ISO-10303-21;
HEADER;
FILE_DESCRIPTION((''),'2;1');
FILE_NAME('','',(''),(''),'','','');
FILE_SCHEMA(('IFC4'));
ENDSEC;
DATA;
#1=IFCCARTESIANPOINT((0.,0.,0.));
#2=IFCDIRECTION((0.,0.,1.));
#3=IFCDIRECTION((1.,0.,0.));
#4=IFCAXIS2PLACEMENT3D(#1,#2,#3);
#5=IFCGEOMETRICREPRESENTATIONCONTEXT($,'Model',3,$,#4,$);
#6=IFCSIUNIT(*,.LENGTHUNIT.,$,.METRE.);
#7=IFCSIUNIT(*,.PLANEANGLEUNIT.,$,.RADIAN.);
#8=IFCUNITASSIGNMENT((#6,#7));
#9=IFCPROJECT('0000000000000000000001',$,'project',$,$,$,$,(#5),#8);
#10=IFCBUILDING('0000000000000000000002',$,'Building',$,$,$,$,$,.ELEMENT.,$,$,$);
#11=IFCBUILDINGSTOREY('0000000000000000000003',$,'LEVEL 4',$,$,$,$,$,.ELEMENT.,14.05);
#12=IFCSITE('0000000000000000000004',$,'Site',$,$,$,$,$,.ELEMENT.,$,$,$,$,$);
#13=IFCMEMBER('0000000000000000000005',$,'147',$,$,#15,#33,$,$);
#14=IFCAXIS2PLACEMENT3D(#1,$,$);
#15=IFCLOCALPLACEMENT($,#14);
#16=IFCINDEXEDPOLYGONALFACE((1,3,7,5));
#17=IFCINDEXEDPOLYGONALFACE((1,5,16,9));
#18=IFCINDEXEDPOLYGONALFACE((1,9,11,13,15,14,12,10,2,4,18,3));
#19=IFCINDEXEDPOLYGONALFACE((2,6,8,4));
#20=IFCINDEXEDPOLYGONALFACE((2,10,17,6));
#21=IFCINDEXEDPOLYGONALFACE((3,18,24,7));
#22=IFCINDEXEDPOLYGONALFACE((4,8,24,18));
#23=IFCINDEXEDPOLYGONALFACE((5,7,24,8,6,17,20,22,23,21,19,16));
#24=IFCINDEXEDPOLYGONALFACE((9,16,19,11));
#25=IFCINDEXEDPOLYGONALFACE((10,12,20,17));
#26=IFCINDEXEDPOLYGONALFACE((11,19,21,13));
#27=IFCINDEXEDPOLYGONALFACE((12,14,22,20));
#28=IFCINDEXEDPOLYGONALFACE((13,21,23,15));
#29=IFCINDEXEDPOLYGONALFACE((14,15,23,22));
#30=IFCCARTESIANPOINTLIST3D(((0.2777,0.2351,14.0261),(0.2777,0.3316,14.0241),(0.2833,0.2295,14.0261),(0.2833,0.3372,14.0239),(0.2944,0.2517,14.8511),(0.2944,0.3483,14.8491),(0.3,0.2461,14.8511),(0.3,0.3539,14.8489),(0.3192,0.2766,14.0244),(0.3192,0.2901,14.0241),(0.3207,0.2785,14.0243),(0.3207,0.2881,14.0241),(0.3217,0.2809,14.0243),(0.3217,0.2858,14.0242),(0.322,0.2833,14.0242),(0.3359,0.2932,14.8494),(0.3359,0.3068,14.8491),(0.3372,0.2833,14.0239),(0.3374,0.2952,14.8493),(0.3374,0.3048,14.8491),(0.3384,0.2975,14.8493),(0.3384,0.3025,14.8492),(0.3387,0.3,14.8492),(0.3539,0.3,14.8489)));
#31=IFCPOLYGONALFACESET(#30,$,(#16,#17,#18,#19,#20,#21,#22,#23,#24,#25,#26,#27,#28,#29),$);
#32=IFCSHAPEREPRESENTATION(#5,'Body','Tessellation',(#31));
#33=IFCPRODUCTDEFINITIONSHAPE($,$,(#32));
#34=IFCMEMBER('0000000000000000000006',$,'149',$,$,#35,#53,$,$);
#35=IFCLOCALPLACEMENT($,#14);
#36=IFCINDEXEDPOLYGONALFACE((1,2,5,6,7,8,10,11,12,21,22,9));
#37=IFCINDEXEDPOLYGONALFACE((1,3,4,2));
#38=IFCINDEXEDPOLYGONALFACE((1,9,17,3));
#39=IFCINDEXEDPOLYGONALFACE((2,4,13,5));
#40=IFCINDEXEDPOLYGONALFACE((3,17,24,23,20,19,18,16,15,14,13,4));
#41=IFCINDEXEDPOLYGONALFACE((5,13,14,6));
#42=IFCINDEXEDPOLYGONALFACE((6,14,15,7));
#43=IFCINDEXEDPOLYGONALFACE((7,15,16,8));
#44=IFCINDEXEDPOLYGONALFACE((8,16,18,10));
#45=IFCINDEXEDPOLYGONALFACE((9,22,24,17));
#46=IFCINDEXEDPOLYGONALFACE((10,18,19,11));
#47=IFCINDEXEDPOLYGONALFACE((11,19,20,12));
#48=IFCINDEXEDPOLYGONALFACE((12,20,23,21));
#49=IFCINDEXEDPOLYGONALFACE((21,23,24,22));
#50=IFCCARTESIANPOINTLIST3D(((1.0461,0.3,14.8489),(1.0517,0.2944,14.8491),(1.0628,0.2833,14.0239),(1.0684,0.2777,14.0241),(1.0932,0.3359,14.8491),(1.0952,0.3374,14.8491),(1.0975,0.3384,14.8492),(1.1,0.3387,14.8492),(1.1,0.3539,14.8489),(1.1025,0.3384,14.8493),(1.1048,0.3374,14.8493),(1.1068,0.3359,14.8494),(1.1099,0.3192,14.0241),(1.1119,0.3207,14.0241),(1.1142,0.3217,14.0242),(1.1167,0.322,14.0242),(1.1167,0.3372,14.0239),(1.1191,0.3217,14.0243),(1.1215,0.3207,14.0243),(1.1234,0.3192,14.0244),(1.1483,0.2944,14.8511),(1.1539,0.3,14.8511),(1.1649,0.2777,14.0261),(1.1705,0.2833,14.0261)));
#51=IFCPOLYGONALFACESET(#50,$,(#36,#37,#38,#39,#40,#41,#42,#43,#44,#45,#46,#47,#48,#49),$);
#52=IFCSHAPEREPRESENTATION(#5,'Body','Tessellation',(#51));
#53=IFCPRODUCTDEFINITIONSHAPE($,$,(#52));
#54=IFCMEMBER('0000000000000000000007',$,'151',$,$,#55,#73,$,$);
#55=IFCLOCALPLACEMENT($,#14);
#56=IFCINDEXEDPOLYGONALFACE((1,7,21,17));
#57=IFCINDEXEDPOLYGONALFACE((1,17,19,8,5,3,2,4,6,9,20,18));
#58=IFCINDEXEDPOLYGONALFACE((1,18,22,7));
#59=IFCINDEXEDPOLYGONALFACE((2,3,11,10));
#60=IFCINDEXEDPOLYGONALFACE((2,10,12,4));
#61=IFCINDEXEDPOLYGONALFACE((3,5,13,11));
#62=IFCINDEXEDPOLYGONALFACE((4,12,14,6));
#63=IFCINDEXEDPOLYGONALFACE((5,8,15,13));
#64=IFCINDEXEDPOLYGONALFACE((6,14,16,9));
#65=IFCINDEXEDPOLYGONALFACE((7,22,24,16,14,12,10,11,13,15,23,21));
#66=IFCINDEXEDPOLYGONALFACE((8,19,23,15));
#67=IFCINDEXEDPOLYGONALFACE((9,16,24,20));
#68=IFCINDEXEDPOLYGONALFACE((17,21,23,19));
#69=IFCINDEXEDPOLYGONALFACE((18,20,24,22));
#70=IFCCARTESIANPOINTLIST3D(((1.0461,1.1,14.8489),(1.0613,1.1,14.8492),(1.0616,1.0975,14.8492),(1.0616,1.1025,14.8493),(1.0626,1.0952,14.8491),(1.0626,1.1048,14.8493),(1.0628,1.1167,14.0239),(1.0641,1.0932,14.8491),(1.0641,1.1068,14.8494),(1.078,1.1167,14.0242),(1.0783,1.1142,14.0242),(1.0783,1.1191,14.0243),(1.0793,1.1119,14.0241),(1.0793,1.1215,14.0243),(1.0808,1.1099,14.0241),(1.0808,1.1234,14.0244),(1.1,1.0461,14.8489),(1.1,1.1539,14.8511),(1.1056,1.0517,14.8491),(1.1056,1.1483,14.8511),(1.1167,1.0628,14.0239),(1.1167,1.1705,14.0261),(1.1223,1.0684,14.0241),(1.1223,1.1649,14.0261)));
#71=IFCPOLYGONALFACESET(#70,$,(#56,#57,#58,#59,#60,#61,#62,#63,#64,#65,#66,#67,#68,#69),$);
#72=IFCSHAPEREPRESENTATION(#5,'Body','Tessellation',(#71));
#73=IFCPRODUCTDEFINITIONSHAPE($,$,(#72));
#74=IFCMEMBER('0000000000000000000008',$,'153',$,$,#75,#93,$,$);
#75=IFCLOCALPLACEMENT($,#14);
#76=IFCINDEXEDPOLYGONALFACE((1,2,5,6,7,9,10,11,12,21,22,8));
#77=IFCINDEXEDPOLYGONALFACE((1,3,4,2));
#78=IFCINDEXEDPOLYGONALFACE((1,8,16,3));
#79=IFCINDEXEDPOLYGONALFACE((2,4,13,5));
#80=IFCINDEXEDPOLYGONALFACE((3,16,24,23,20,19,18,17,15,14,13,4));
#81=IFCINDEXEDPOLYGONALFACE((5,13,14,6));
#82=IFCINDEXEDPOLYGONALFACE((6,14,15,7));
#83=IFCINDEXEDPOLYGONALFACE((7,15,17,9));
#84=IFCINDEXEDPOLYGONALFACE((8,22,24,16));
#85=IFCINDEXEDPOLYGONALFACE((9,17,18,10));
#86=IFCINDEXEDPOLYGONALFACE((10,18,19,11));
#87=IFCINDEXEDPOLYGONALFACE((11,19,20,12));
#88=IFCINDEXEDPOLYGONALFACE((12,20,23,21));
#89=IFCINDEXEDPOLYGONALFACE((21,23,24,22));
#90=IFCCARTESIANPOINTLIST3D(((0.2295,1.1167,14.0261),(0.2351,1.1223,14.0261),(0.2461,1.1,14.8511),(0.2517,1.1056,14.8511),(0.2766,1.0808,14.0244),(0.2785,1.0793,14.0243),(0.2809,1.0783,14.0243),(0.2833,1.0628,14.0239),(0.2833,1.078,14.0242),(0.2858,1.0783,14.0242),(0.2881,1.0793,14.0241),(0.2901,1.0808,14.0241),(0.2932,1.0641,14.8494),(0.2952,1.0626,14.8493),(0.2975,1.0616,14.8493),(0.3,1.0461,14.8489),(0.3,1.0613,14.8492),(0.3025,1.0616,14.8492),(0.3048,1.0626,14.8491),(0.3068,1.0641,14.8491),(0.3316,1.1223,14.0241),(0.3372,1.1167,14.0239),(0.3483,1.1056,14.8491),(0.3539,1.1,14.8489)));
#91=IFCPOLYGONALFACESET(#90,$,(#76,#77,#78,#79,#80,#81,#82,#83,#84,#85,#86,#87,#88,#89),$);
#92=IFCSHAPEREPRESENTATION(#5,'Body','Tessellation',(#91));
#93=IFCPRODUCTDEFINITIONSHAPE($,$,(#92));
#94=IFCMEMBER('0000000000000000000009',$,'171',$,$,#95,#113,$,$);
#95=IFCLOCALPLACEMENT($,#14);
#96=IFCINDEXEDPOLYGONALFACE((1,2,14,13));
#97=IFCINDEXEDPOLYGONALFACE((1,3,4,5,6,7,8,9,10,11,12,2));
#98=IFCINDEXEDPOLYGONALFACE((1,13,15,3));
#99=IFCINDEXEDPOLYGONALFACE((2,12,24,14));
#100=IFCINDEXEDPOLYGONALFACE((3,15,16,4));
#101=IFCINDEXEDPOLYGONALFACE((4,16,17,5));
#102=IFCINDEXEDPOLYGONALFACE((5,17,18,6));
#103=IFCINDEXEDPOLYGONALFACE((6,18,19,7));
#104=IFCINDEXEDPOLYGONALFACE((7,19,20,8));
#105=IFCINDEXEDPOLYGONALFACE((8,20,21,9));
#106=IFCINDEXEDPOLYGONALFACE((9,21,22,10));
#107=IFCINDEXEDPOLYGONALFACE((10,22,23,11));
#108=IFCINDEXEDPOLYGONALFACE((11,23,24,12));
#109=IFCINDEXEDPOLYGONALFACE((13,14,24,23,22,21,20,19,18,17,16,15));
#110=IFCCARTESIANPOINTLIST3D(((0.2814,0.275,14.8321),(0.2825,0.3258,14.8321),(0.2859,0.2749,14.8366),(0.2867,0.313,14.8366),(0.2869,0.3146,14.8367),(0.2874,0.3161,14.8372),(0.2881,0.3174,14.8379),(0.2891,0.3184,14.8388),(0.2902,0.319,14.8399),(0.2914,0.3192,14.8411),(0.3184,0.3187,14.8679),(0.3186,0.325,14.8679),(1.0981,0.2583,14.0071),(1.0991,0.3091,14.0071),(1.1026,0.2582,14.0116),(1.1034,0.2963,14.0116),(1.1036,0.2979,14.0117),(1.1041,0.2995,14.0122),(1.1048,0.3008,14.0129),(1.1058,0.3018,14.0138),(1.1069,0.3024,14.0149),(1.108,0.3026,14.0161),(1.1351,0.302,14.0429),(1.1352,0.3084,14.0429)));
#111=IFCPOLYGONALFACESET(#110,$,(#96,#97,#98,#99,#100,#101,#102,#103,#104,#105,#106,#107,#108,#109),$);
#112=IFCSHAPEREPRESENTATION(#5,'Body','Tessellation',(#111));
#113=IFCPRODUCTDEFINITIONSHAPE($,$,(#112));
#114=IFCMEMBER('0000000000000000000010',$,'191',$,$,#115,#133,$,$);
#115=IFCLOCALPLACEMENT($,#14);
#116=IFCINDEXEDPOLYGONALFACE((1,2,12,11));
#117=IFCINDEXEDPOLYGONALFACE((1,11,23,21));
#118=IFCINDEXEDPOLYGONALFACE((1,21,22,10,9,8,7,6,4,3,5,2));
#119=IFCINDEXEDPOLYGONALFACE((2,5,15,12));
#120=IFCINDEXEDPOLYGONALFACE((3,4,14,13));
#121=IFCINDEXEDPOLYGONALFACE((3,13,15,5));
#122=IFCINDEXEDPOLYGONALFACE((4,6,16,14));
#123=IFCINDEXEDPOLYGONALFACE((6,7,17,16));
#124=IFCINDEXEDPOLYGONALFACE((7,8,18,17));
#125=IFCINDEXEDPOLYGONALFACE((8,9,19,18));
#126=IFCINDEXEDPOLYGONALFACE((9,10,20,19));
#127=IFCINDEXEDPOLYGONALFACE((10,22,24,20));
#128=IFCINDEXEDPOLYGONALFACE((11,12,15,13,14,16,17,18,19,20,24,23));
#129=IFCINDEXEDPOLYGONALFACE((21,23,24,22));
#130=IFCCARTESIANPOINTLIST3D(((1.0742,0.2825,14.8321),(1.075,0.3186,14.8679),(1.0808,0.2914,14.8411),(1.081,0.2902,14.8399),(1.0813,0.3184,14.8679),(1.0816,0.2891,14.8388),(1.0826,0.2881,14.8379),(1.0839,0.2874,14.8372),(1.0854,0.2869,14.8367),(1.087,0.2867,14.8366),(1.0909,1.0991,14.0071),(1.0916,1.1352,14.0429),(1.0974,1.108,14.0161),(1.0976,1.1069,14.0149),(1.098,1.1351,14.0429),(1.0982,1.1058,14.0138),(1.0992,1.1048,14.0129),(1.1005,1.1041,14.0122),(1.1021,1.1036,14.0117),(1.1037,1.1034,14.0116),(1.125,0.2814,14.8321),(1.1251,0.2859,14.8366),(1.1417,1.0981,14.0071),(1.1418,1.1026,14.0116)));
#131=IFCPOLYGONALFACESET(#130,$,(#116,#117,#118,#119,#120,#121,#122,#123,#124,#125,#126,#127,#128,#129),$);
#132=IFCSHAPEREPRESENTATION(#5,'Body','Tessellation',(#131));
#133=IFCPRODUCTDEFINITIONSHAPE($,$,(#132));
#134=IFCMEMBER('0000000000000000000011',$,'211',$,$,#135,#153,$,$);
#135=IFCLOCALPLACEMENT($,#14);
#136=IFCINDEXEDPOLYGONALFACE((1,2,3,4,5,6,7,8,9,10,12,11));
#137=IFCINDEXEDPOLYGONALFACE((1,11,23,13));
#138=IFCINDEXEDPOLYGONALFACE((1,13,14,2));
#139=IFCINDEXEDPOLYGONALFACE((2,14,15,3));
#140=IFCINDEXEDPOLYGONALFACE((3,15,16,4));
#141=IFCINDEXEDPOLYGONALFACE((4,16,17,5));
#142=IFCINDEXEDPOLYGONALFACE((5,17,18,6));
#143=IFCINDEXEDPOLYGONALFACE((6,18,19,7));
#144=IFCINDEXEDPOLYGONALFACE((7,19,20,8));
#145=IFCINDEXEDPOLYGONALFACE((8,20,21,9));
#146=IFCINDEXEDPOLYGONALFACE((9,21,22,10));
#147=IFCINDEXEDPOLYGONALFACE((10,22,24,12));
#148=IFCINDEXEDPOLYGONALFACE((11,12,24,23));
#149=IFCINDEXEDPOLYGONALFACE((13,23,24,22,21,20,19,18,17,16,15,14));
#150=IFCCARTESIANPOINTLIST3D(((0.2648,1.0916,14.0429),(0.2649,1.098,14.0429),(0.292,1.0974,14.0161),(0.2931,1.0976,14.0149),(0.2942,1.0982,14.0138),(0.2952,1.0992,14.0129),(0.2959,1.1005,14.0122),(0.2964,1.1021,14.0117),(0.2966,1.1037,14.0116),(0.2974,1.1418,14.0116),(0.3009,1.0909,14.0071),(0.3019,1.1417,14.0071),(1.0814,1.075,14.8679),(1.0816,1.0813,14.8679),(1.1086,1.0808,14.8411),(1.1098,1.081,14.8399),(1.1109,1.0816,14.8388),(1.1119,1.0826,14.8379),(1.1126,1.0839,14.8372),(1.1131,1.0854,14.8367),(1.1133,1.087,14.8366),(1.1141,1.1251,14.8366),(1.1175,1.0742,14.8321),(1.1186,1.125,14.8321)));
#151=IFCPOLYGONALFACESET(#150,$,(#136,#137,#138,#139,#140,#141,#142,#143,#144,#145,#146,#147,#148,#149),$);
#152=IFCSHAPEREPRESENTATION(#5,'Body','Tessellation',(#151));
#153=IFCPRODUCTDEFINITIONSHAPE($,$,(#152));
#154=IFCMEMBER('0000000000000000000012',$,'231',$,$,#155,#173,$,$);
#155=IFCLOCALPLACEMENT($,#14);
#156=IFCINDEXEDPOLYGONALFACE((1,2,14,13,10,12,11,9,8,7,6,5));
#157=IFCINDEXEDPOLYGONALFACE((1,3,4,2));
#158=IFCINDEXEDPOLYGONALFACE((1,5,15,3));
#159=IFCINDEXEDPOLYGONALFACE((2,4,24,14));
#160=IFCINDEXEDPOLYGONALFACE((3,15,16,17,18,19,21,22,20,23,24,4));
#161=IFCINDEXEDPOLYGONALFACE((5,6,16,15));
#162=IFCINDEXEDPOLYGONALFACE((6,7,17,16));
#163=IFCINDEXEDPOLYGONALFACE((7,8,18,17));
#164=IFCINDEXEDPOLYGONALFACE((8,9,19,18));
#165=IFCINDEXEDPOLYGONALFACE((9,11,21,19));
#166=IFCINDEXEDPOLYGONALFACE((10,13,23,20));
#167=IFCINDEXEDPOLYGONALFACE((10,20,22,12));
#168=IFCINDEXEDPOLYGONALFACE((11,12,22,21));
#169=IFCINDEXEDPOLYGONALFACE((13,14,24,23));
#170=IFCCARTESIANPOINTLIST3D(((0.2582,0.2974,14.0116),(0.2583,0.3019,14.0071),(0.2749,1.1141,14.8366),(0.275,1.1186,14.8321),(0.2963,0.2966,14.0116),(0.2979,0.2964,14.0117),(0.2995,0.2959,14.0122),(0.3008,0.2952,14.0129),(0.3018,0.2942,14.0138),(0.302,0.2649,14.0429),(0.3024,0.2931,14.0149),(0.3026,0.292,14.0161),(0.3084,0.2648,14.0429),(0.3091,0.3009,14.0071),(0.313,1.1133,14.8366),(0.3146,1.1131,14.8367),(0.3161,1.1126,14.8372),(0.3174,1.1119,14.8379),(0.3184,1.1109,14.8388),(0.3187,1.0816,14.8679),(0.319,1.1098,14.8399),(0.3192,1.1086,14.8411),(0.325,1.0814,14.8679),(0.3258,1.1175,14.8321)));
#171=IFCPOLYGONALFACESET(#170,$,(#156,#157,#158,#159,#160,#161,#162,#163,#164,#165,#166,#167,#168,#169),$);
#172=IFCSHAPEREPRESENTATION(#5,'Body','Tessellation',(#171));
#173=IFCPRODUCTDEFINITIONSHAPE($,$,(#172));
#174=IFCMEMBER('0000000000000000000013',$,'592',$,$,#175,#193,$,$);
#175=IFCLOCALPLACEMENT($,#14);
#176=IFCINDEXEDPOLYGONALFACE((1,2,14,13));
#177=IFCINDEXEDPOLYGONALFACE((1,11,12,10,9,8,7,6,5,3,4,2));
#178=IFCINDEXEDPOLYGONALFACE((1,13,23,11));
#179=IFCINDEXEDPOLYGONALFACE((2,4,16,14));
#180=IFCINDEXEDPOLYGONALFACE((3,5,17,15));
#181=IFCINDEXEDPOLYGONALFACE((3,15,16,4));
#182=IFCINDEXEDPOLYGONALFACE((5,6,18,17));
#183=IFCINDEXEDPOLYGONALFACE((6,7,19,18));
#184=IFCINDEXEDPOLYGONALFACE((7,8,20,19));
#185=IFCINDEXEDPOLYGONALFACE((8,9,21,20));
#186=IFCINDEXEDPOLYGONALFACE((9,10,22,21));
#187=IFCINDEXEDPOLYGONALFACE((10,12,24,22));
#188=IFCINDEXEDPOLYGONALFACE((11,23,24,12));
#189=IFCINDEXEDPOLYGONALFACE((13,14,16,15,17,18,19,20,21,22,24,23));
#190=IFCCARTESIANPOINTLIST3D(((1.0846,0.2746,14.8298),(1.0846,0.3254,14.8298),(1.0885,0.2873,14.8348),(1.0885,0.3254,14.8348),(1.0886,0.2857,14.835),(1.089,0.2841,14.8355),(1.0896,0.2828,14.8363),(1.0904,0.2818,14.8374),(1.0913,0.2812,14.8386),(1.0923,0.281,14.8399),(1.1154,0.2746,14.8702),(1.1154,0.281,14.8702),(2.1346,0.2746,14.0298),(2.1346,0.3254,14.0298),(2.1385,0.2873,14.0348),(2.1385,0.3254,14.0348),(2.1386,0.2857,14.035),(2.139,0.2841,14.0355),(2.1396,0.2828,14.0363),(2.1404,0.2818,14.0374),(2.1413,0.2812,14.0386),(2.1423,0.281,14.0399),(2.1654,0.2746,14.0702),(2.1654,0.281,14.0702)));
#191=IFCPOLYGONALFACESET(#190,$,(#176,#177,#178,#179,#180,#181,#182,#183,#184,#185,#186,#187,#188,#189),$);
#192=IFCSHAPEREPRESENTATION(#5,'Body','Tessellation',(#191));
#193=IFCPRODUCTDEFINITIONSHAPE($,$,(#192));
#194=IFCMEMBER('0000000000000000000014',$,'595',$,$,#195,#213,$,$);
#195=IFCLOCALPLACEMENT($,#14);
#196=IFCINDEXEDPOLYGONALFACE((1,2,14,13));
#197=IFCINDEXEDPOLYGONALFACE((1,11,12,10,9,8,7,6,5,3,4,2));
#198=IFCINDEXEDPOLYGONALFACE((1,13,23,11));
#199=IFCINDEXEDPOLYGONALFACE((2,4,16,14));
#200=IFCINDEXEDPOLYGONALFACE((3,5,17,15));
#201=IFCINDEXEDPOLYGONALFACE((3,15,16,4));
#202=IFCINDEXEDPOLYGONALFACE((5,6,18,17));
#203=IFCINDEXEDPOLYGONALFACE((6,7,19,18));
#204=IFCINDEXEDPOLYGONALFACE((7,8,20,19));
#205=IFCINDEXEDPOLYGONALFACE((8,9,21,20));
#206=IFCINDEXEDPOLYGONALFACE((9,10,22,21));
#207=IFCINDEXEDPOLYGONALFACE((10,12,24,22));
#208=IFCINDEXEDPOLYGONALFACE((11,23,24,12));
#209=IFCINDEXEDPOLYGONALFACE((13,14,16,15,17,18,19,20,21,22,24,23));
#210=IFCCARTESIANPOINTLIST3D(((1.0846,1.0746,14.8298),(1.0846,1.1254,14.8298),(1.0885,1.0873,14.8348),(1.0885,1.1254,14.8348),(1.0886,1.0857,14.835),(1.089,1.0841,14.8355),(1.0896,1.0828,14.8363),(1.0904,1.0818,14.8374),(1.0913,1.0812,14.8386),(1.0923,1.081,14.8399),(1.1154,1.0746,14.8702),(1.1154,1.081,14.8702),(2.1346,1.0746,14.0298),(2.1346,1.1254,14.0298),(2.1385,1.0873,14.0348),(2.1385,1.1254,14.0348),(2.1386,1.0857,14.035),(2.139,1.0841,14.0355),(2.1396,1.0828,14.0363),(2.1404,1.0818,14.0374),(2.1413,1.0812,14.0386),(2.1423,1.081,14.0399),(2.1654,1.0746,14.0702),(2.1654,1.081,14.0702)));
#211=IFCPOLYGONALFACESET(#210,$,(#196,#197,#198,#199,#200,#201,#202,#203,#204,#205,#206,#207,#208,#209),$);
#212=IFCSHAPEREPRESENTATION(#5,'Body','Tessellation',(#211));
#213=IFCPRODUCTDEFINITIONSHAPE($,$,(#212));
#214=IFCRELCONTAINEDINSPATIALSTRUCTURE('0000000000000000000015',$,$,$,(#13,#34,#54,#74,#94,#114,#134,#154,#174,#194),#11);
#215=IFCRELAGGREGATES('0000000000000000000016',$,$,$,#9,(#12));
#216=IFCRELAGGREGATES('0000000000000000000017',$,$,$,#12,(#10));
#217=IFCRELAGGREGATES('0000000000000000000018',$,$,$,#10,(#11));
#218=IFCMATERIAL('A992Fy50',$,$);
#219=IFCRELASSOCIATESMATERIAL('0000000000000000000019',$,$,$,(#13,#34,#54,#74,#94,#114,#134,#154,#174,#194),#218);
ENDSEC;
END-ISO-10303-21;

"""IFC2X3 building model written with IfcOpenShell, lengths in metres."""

from ifc_helpers import new_model, si_unit, frame, origin_with_axes, origin_2d_with_axis, place, context, project, spatial, l_section, extrude, material, element, save


model = new_model("IFC2X3")

# Units and contexts
model_context = context("Model", 3, world=origin_with_axes())
ifc_project = project(units=[si_unit("LENGTHUNIT", "METRE"), si_unit("PLANEANGLEUNIT", "RADIAN")], contexts=[model_context])

# Site, building, storey
site = spatial("IfcSite", under=ifc_project, Name="Site", CompositionType="ELEMENT")
building = spatial("IfcBuilding", under=site, Name="Building", CompositionType="ELEMENT")
storey = spatial("IfcBuildingStorey", under=building, Name="LEVEL 4", CompositionType="ELEMENT", Elevation=14.05)

# Shared definitions
ifc_material = material(Name="A992Fy50")

# Members
for number, where, z_axis, x_axis, name in (
    (1, (0.2833, 0.2833, 14.025), (0.020194, 0.020194, 0.999592), (-0.707107, 0.707107, 0.0), "147"),
    (2, (1.1167, 0.2833, 14.025), (-0.020194, 0.020194, 0.999592), (-0.707107, -0.707107, 0.0), "149"),
    (3, (1.1167, 1.1167, 14.025), (-0.020194, -0.020194, 0.999592), (0.707107, -0.707107, 0.0), "151"),
    (4, (0.2833, 1.1167, 14.025), (0.020194, -0.020194, 0.999592), (0.707107, 0.707107, 0.0), "153"),
):
    element("IfcMember", number, at=place(None, frame(where, z_axis=z_axis, x_axis=x_axis)), inside=storey, material=ifc_material, Name=name, context=model_context, shape_type="SweptSolid", body=[
        extrude(l_section(Depth=0.0762, Width=0.0762, Thickness=0.0079, FilletRadius=0.0096, at=origin_2d_with_axis()), origin_with_axes(), (0.0, 0.0, 1.0), 0.8253),
    ])
for number, where, z_axis, x_axis, name in (
    (5, (1.1167, 0.2833, 14.025), (-0.703436, 0.014356, 0.710614), (-0.020404, -0.999792, 0.0), "171"),
    (6, (1.1167, 1.1167, 14.025), (-0.014356, -0.703436, 0.710614), (0.999792, -0.020404, 0.0), "191"),
    (7, (0.2833, 1.1167, 14.025), (0.703436, -0.014356, 0.710614), (0.020404, 0.999792, 0.0), "211"),
    (8, (0.2833, 0.2833, 14.025), (0.014356, 0.703436, 0.710614), (-0.999792, 0.020404, 0.0), "231"),
):
    element("IfcMember", number, at=place(None, frame(where, z_axis=z_axis, x_axis=x_axis)), inside=storey, material=ifc_material, Name=name, context=model_context, shape_type="SweptSolid", body=[
        extrude(l_section(Depth=0.0508, Width=0.0508, Thickness=0.0063, FilletRadius=0.0063, at=origin_2d_with_axis()), origin_with_axes(), (0.0, 0.0, 1.0), 1.161),
    ])
for number, where, z_axis, x_axis, name in (
    (9, (1.1, 0.3, 14.85), (0.795432, 0.0, -0.606043), (0.0, 1.0, 0.0), "592"),
    (10, (1.1, 1.1, 14.85), (0.795432, 0.0, -0.606043), (0.0, 1.0, 0.0), "595"),
):
    element("IfcMember", number, at=place(None, frame(where, z_axis=z_axis, x_axis=x_axis)), inside=storey, material=ifc_material, Name=name, context=model_context, shape_type="SweptSolid", body=[
        extrude(l_section(Depth=0.0508, Width=0.0508, Thickness=0.0063, FilletRadius=0.0063, at=origin_2d_with_axis()), origin_with_axes(), (0.0, 0.0, 1.0), 1.32),
    ])

save(model, "model.ifc")
